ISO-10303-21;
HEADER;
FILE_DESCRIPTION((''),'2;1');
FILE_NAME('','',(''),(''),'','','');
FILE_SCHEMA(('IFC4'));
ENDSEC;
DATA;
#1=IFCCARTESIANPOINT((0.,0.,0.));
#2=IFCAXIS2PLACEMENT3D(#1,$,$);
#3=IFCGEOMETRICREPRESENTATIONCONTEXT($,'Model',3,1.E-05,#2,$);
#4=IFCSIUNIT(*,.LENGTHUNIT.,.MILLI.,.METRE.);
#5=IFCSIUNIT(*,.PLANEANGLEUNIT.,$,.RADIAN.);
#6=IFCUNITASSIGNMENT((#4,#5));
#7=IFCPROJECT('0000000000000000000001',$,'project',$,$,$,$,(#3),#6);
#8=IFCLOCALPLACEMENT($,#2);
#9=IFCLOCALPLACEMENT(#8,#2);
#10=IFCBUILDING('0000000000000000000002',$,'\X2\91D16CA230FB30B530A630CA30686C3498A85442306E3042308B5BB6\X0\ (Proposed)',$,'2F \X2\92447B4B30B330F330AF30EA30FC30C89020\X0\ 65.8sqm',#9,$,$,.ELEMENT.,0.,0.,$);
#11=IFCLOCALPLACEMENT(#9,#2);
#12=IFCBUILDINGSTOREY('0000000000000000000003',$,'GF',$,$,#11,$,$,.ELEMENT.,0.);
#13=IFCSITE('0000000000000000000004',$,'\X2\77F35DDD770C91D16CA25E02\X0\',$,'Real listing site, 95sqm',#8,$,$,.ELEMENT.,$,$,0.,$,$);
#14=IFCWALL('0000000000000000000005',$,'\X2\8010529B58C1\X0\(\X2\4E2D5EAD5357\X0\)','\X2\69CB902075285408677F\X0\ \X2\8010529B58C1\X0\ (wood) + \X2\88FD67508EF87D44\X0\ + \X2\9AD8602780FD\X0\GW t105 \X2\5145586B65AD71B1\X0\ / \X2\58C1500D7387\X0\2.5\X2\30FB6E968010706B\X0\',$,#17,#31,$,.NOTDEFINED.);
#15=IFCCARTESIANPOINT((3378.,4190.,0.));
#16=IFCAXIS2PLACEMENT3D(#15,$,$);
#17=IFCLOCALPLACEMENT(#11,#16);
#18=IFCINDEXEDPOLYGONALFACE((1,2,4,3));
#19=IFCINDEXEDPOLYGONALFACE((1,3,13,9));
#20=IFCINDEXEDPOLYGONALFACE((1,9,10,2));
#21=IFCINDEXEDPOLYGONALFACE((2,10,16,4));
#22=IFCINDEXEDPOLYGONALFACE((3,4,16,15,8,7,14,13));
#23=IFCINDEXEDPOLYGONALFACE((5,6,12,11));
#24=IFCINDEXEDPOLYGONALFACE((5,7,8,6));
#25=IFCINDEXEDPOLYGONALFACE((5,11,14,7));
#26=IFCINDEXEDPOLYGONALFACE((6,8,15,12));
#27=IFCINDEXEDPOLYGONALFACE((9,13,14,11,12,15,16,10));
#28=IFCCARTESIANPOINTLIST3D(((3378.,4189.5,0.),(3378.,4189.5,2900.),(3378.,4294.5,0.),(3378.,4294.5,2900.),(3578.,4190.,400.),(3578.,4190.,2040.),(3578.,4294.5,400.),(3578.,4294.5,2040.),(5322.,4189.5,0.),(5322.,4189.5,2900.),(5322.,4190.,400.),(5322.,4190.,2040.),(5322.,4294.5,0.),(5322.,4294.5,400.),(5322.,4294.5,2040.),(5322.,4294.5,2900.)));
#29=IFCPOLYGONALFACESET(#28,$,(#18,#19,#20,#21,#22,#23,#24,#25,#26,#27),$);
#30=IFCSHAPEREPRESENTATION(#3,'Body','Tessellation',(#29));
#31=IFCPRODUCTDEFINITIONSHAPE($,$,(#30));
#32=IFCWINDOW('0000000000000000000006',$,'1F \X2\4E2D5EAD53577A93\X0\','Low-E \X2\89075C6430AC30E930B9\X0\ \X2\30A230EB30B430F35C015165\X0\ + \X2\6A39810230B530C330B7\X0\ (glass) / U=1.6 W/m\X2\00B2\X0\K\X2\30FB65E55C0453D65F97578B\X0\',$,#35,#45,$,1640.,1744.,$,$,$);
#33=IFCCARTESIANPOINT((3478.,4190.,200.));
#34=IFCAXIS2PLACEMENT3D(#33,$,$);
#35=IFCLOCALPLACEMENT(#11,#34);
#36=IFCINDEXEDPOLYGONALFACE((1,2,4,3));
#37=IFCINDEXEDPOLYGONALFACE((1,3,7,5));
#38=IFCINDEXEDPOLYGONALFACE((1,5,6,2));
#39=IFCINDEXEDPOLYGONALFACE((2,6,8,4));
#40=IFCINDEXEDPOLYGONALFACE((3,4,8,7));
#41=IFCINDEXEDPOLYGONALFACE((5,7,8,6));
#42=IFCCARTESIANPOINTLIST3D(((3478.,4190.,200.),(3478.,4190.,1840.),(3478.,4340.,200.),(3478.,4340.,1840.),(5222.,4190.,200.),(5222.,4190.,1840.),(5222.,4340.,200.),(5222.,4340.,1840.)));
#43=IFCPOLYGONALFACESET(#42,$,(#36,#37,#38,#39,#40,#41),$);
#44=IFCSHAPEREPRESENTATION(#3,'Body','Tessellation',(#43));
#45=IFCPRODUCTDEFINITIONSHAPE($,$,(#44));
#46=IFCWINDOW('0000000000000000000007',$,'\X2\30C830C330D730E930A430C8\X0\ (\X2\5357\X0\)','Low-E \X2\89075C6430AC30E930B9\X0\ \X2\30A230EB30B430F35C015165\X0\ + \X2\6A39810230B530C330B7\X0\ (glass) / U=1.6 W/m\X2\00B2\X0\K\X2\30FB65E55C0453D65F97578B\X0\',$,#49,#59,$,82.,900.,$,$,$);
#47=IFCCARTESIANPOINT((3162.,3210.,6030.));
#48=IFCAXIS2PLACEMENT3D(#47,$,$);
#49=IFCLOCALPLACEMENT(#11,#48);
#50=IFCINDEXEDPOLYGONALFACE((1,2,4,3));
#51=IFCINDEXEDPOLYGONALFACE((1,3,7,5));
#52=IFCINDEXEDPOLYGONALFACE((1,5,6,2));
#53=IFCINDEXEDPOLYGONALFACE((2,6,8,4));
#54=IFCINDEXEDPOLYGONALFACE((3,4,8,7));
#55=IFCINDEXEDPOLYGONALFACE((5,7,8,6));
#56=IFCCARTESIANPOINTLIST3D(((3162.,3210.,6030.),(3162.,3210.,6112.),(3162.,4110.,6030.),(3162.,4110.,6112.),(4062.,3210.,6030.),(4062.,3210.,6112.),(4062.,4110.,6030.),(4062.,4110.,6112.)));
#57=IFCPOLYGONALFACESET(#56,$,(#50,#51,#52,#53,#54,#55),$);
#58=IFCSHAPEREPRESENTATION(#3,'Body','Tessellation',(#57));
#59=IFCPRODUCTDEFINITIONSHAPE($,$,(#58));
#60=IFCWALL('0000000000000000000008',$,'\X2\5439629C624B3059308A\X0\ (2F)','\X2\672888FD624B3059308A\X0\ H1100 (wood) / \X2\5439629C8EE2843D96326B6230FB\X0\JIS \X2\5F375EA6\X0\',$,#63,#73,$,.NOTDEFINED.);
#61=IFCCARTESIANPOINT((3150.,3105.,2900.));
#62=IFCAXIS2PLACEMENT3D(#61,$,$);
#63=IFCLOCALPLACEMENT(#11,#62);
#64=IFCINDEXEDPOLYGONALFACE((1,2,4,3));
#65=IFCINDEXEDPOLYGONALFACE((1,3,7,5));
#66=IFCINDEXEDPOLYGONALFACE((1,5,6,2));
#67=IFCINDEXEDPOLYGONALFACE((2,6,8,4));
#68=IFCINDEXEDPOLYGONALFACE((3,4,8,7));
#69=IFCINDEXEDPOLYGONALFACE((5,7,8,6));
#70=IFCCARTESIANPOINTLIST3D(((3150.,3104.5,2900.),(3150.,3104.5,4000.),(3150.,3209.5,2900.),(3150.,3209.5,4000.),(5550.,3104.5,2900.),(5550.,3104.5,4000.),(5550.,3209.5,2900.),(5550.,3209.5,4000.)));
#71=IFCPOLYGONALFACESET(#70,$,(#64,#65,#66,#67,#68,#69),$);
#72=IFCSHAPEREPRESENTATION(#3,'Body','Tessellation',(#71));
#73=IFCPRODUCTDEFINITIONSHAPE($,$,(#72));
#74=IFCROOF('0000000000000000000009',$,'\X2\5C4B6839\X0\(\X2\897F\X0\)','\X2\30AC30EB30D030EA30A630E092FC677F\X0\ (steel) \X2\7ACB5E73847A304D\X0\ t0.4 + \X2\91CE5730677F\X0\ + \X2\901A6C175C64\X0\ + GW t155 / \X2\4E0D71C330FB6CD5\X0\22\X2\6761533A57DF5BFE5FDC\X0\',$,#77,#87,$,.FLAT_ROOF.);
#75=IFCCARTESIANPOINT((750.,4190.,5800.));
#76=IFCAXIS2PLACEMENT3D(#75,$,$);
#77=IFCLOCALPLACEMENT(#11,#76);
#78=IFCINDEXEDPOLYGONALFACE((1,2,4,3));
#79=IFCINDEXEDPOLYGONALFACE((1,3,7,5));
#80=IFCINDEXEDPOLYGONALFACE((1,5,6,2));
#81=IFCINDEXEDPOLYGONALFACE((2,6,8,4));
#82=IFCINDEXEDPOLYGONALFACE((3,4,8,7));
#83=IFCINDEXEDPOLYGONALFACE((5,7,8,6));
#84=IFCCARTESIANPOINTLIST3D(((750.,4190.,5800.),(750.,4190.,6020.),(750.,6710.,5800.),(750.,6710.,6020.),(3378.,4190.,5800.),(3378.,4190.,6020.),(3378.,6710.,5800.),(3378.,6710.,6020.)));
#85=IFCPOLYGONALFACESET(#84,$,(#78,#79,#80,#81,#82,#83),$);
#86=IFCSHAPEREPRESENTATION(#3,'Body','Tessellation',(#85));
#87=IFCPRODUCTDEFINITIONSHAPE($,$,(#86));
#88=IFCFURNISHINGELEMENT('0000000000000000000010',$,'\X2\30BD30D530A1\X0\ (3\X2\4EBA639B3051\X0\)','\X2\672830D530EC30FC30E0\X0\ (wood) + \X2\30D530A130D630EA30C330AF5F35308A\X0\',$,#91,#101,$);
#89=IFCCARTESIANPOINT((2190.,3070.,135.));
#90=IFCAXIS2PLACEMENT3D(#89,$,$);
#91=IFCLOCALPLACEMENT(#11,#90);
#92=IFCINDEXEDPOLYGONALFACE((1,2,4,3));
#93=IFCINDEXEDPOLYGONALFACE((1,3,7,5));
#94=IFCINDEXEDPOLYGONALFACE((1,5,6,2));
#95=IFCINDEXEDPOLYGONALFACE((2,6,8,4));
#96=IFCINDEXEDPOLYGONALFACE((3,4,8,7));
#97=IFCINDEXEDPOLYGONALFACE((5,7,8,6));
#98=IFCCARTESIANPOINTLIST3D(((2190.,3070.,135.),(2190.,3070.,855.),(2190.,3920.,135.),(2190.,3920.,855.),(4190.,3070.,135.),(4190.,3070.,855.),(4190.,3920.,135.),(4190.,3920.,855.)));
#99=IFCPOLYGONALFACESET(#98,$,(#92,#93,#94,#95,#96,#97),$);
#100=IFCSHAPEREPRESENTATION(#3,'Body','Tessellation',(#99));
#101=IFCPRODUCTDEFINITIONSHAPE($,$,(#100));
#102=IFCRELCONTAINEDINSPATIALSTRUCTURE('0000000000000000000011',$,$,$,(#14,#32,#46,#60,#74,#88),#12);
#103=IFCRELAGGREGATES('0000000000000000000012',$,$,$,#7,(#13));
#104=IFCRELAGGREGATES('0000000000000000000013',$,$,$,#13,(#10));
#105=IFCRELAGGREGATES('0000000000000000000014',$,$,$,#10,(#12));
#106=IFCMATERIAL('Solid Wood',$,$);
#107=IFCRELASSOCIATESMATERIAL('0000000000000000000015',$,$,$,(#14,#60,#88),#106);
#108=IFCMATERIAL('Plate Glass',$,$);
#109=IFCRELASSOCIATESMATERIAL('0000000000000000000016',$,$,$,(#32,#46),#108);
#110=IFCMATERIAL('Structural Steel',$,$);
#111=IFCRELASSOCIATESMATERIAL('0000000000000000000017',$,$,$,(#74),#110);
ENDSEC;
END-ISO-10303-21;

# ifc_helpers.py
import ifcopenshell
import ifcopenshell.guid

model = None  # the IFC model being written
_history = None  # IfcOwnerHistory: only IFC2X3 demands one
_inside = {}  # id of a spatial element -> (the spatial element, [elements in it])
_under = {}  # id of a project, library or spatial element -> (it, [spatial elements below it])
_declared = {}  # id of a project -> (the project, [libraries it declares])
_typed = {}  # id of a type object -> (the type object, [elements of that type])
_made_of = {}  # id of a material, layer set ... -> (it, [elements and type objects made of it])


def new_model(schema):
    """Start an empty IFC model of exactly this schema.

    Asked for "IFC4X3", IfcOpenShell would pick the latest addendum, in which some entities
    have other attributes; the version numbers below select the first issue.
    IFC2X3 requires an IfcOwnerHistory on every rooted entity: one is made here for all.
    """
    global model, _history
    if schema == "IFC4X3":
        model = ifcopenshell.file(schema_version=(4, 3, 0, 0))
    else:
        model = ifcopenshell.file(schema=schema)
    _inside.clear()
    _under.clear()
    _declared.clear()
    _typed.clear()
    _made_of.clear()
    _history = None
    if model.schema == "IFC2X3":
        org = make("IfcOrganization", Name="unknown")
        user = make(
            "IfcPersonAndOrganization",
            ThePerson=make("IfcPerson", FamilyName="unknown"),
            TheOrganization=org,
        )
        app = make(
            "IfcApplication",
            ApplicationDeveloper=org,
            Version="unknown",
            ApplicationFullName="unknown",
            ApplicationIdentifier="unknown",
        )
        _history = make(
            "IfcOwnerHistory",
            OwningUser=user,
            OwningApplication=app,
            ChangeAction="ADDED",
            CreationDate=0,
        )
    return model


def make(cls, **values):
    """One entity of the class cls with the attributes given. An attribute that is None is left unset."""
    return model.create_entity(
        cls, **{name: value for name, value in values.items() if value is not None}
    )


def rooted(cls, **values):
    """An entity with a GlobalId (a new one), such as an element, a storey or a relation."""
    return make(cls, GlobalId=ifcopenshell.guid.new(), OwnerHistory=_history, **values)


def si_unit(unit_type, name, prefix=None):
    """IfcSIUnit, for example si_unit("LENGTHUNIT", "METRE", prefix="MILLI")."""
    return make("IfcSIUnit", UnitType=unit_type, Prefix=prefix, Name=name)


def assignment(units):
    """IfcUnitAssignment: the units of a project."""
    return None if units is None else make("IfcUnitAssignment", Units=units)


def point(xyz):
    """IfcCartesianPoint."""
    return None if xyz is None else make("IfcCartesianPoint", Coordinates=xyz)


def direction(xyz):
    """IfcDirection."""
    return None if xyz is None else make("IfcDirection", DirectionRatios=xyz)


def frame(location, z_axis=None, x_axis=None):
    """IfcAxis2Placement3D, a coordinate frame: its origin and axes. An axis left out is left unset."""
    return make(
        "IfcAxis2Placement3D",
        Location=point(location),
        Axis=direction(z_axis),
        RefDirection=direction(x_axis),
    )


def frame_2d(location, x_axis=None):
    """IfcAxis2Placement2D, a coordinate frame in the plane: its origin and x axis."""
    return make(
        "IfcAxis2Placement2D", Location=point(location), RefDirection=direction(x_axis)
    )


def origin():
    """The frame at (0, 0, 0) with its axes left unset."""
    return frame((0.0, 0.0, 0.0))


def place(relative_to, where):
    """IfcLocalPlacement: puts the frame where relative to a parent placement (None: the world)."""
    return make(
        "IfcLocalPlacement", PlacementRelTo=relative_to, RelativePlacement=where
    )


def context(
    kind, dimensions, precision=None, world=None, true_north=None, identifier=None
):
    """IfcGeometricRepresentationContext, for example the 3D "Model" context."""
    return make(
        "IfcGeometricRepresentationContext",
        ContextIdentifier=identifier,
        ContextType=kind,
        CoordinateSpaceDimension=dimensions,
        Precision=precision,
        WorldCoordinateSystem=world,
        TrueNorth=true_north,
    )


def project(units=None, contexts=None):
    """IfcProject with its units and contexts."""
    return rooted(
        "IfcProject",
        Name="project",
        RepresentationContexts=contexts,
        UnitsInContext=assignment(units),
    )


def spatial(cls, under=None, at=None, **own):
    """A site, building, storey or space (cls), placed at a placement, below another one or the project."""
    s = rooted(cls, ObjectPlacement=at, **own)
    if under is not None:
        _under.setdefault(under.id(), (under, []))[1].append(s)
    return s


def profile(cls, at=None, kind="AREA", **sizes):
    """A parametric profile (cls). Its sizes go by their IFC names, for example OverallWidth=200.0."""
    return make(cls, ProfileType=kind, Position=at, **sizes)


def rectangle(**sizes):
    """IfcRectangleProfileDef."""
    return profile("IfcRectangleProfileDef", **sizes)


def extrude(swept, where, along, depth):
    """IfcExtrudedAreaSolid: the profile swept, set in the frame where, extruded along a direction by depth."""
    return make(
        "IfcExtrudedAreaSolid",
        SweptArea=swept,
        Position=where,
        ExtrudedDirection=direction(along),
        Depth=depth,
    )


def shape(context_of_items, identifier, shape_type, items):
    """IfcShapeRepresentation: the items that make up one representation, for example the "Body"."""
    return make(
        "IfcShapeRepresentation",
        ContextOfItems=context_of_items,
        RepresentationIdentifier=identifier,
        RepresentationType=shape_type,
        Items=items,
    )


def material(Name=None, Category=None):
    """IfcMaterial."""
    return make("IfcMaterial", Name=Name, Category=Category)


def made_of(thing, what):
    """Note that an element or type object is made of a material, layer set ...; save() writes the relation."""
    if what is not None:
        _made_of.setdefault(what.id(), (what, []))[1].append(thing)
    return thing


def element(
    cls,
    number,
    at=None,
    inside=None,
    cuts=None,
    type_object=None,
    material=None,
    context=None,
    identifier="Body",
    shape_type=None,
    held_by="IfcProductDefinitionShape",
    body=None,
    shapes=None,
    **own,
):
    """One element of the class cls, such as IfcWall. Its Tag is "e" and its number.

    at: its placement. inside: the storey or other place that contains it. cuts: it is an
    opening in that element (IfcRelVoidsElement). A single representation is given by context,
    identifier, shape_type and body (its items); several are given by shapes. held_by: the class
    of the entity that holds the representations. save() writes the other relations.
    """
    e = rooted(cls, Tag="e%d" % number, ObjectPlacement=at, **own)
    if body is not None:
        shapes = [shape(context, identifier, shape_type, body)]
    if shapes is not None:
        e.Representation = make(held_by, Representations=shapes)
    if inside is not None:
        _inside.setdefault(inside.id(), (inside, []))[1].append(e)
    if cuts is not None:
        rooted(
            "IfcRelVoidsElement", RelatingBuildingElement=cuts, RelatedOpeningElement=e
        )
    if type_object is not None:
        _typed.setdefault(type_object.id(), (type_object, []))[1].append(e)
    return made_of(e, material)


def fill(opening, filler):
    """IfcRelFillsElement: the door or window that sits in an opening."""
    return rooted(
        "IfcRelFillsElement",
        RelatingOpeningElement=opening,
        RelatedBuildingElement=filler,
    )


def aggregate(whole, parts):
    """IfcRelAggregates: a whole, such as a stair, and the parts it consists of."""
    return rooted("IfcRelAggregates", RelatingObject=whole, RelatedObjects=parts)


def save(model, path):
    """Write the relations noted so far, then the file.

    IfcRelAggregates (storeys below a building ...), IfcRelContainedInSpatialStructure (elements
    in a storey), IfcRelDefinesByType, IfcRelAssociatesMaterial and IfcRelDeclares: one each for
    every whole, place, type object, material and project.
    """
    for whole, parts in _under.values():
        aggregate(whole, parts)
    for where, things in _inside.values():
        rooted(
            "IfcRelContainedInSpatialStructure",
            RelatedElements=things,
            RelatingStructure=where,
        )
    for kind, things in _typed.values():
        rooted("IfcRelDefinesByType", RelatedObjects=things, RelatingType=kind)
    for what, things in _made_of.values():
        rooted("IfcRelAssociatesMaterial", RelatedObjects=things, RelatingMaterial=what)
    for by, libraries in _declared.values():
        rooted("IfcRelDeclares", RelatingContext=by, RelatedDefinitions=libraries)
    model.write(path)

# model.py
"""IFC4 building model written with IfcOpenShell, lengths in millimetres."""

from ifc_helpers import new_model, si_unit, frame, frame_2d, origin, place, context, project, spatial, rectangle, extrude, material, element, fill, save


model = new_model("IFC4")

# Units and contexts
model_context = context("Model", 3, precision=1e-05, world=origin())
ifc_project = project(units=[si_unit("LENGTHUNIT", "METRE", prefix="MILLI"), si_unit("PLANEANGLEUNIT", "RADIAN")], contexts=[model_context])

# Site, building, storey
site_placement = place(None, origin())
site = spatial("IfcSite", under=ifc_project, at=site_placement, Name="石川県金沢市", ObjectType="Real listing site, 95sqm", CompositionType="ELEMENT", RefElevation=0.0)
building_placement = place(site_placement, origin())
building = spatial("IfcBuilding", under=site, at=building_placement, Name="金沢・サウナと水風呂のある家 (Proposed)", ObjectType="2F 鉄筋コンクリート造 65.8sqm", CompositionType="ELEMENT", ElevationOfRefHeight=0.0, ElevationOfTerrain=0.0)
storey_placement = place(building_placement, origin())
storey = spatial("IfcBuildingStorey", under=building, at=storey_placement, Name="GF", CompositionType="ELEMENT", Elevation=0.0)

# Shared definitions
ifc_material_1 = material(Name="Solid Wood")

# Wall, opening, window
wall_1_placement = place(storey_placement, frame((3378.0, 4190.0, 0.0)))
wall_1 = element("IfcWall", 1, at=wall_1_placement, inside=storey, material=ifc_material_1, Name="耐力壁(中庭南)", Description="構造用合板 耐力壁 (wood) + 製材軸組 + 高性能GW t105 充填断熱 / 壁倍率2.5・準耐火", PredefinedType="NOTDEFINED", context=model_context, shape_type="SweptSolid", body=[
    extrude(rectangle(XDim=1944.0, YDim=105.0, at=frame_2d((972.0, 52.0))), frame((3378.0, 4190.0, 0.0)), (0.0, 0.0, 1.0), 2900.0),
])
opening_placement = place(storey_placement, frame((3478.0, 4190.0, 200.0)))
opening = element("IfcOpeningElement", 2, at=opening_placement, cuts=wall_1, PredefinedType="NOTDEFINED", context=model_context, shape_type="SweptSolid", body=[
    extrude(rectangle(XDim=1744.0, YDim=150.0, at=frame_2d((872.0, 75.0))), frame((3478.0, 4190.0, 200.0)), (0.0, 0.0, 1.0), 1640.0),
])
ifc_material_2 = material(Name="Plate Glass")
window_1_placement = place(storey_placement, frame((3478.0, 4190.0, 200.0)))
window_1 = element("IfcWindow", 3, at=window_1_placement, inside=storey, material=ifc_material_2, Name="1F 中庭南窓", Description="Low-E 複層ガラス アルゴン封入 + 樹脂サッシ (glass) / U=1.6 W/m²K・日射取得型", OverallHeight=1640.0, OverallWidth=1744.0, context=model_context, shape_type="SweptSolid", body=[
    extrude(rectangle(XDim=1744.0, YDim=150.0, at=frame_2d((872.0, 75.0))), frame((3478.0, 4190.0, 200.0)), (0.0, 0.0, 1.0), 1640.0),
])
fill(opening, window_1)

# Window
window_2_placement = place(storey_placement, frame((3162.0, 3210.0, 6030.0)))
element("IfcWindow", 4, at=window_2_placement, inside=storey, material=ifc_material_2, Name="トップライト (南)", Description="Low-E 複層ガラス アルゴン封入 + 樹脂サッシ (glass) / U=1.6 W/m²K・日射取得型", OverallHeight=82.0, OverallWidth=900.0, context=model_context, shape_type="SweptSolid", body=[
    extrude(rectangle(XDim=900.0, YDim=900.0, at=frame_2d((450.0, 450.0))), frame((3162.0, 3210.0, 6030.0)), (0.0, 0.0, 1.0), 82.0),
])

# Wall
wall_2_placement = place(storey_placement, frame((3150.0, 3105.0, 2900.0)))
element("IfcWall", 5, at=wall_2_placement, inside=storey, material=ifc_material_1, Name="吹抜手すり (2F)", Description="木製手すり H1100 (wood) / 吹抜転落防止・JIS 強度", PredefinedType="NOTDEFINED", context=model_context, shape_type="SweptSolid", body=[
    extrude(rectangle(XDim=2400.0, YDim=105.0, at=frame_2d((1200.0, 52.0))), frame((3150.0, 3105.0, 2900.0)), (0.0, 0.0, 1.0), 1100.0),
])

# Roof
ifc_material_3 = material(Name="Structural Steel")
for number, where, name in (
    (6, (750.0, 4190.0, 5800.0), "屋根(西)"),
):
    element("IfcRoof", number, at=place(storey_placement, frame(where)), inside=storey, material=ifc_material_3, Name=name, Description="ガルバリウム鋼板 (steel) 立平葺き t0.4 + 野地板 + 通気層 + GW t155 / 不燃・法22条区域対応", PredefinedType="FLAT_ROOF", context=model_context, shape_type="SweptSolid", body=[
        extrude(rectangle(XDim=2628.0, YDim=2520.0, at=frame_2d((1314.0, 1260.0))), frame((750.0, 4190.0, 5800.0)), (0.0, 0.0, 1.0), 220.0),
    ])

# Furnishing element
furnishing_placement = place(storey_placement, frame((2190.0, 3070.0, 135.0)))
element("IfcFurnishingElement", 7, at=furnishing_placement, inside=storey, material=ifc_material_1, Name="ソファ (3人掛け)", Description="木フレーム (wood) + ファブリック張り", context=model_context, shape_type="SweptSolid", body=[
    extrude(rectangle(XDim=2000.0, YDim=850.0, at=frame_2d((1000.0, 425.0))), frame((2190.0, 3070.0, 135.0)), (0.0, 0.0, 1.0), 720.0),
])

save(model, "model.ifc")
